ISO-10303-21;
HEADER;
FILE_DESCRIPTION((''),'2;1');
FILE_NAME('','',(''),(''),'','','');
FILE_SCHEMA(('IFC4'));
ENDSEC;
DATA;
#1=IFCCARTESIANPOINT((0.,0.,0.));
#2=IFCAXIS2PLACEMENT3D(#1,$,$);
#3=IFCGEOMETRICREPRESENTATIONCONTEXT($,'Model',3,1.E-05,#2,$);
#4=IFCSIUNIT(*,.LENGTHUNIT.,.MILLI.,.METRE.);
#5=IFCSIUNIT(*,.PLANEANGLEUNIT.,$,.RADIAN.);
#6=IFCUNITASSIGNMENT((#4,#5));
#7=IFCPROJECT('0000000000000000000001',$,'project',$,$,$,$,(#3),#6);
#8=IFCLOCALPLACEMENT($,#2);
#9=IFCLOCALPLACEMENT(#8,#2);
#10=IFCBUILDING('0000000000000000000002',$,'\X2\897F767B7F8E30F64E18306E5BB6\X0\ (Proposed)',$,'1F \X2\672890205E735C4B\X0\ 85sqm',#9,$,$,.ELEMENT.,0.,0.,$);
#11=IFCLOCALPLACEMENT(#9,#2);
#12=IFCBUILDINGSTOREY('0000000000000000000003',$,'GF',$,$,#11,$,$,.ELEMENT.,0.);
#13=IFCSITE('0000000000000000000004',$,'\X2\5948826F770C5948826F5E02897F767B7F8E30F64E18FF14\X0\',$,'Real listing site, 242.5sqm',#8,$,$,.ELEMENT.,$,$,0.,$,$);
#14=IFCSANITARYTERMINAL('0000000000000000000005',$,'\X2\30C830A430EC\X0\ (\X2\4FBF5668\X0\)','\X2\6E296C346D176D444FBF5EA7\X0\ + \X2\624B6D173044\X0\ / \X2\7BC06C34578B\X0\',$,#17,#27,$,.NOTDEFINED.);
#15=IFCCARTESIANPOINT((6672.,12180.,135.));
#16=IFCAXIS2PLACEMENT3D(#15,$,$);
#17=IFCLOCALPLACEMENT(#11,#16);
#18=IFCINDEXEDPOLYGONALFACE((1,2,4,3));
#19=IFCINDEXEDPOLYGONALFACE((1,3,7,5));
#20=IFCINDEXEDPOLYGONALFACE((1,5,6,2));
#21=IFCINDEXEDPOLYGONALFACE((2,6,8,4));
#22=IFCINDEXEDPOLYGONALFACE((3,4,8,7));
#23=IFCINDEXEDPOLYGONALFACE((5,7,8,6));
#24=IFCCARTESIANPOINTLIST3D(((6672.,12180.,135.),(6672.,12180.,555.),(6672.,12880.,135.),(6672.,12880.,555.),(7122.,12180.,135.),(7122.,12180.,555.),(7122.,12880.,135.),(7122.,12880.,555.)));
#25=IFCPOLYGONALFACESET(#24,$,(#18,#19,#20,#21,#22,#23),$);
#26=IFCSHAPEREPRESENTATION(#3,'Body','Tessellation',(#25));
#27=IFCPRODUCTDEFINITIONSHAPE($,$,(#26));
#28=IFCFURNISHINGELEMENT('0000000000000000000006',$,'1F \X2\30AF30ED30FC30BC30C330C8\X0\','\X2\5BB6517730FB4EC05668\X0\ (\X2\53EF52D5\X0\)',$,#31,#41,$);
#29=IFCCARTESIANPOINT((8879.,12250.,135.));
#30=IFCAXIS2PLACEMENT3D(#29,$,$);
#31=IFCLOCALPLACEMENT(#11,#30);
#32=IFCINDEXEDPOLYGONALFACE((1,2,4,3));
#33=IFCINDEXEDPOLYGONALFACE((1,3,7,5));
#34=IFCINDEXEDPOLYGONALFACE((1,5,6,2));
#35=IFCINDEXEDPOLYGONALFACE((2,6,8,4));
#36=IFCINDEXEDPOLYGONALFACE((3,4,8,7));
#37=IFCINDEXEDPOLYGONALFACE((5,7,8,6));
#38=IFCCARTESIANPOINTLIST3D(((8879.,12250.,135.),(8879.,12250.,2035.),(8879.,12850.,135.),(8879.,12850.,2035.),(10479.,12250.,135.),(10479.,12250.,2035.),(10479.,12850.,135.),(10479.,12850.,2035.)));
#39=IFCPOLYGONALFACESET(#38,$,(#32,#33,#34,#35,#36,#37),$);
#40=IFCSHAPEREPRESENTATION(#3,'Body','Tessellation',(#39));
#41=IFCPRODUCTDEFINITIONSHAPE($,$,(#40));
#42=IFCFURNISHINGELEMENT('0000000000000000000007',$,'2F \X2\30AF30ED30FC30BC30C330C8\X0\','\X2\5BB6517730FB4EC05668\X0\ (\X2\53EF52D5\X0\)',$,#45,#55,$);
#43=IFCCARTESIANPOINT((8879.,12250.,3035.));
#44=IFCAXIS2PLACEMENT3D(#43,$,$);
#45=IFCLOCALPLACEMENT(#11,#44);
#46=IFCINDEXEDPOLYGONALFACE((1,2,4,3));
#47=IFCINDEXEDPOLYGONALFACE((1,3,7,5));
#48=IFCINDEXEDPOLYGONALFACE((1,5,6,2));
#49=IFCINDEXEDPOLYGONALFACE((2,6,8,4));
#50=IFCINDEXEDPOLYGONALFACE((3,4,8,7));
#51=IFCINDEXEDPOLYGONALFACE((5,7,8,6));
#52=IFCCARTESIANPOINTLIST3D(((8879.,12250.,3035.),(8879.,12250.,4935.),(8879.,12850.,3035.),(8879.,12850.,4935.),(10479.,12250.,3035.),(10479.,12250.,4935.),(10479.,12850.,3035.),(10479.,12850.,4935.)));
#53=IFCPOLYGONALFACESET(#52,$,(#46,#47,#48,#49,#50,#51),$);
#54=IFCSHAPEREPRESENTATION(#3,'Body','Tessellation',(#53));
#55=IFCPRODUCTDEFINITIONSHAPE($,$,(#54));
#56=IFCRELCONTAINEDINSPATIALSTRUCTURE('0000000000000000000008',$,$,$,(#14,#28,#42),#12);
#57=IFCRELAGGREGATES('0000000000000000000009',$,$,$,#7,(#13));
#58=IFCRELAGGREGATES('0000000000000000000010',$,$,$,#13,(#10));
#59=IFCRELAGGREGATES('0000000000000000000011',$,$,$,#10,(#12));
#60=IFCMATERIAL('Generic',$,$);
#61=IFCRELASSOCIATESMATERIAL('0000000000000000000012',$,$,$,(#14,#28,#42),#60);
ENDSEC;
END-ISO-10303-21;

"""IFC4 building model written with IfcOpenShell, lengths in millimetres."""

from ifc_helpers import new_model, si_unit, frame, frame_2d, origin, place, context, project, spatial, rectangle, extrude, material, element, save


model = new_model("IFC4")

# Units and contexts
model_context = context("Model", 3, precision=1e-05, world=origin())
ifc_project = project(units=[si_unit("LENGTHUNIT", "METRE", prefix="MILLI"), si_unit("PLANEANGLEUNIT", "RADIAN")], contexts=[model_context])

# Site, building, storey
site_placement = place(None, origin())
site = spatial("IfcSite", under=ifc_project, at=site_placement, Name="奈良県奈良市西登美ヶ丘４", ObjectType="Real listing site, 242.5sqm", CompositionType="ELEMENT", RefElevation=0.0)
building_placement = place(site_placement, origin())
building = spatial("IfcBuilding", under=site, at=building_placement, Name="西登美ヶ丘の家 (Proposed)", ObjectType="1F 木造平屋 85sqm", CompositionType="ELEMENT", ElevationOfRefHeight=0.0, ElevationOfTerrain=0.0)
storey_placement = place(building_placement, origin())
storey = spatial("IfcBuildingStorey", under=building, at=storey_placement, Name="GF", CompositionType="ELEMENT", Elevation=0.0)

# Sanitary terminal
ifc_material_1 = material(Name="Generic")
sanitary_terminal_1_placement = place(storey_placement, frame((6672.0, 12180.0, 135.0)))
element("IfcSanitaryTerminal", 1, at=sanitary_terminal_1_placement, inside=storey, material=ifc_material_1, Name="トイレ (便器)", Description="温水洗浄便座 + 手洗い / 節水型", PredefinedType="NOTDEFINED", context=model_context, shape_type="SweptSolid", body=[
    extrude(rectangle(XDim=450.0, YDim=700.0, at=frame_2d((225.0, 350.0))), frame((6672.0, 12180.0, 135.0)), (0.0, 0.0, 1.0), 420.0),
])

# Furnishing elements
furnishing_1_placement = place(storey_placement, frame((8879.0, 12250.0, 135.0)))
element("IfcFurnishingElement", 2, at=furnishing_1_placement, inside=storey, material=ifc_material_1, Name="1F クローゼット", Description="家具・什器 (可動)", context=model_context, shape_type="SweptSolid", body=[
    extrude(rectangle(XDim=1600.0, YDim=600.0, at=frame_2d((800.0, 300.0))), frame((8879.0, 12250.0, 135.0)), (0.0, 0.0, 1.0), 1900.0),
])
furnishing_2_placement = place(storey_placement, frame((8879.0, 12250.0, 3035.0)))
element("IfcFurnishingElement", 3, at=furnishing_2_placement, inside=storey, material=ifc_material_1, Name="2F クローゼット", Description="家具・什器 (可動)", context=model_context, shape_type="SweptSolid", body=[
    extrude(rectangle(XDim=1600.0, YDim=600.0, at=frame_2d((800.0, 300.0))), frame((8879.0, 12250.0, 3035.0)), (0.0, 0.0, 1.0), 1900.0),
])

save(model, "model.ifc")
